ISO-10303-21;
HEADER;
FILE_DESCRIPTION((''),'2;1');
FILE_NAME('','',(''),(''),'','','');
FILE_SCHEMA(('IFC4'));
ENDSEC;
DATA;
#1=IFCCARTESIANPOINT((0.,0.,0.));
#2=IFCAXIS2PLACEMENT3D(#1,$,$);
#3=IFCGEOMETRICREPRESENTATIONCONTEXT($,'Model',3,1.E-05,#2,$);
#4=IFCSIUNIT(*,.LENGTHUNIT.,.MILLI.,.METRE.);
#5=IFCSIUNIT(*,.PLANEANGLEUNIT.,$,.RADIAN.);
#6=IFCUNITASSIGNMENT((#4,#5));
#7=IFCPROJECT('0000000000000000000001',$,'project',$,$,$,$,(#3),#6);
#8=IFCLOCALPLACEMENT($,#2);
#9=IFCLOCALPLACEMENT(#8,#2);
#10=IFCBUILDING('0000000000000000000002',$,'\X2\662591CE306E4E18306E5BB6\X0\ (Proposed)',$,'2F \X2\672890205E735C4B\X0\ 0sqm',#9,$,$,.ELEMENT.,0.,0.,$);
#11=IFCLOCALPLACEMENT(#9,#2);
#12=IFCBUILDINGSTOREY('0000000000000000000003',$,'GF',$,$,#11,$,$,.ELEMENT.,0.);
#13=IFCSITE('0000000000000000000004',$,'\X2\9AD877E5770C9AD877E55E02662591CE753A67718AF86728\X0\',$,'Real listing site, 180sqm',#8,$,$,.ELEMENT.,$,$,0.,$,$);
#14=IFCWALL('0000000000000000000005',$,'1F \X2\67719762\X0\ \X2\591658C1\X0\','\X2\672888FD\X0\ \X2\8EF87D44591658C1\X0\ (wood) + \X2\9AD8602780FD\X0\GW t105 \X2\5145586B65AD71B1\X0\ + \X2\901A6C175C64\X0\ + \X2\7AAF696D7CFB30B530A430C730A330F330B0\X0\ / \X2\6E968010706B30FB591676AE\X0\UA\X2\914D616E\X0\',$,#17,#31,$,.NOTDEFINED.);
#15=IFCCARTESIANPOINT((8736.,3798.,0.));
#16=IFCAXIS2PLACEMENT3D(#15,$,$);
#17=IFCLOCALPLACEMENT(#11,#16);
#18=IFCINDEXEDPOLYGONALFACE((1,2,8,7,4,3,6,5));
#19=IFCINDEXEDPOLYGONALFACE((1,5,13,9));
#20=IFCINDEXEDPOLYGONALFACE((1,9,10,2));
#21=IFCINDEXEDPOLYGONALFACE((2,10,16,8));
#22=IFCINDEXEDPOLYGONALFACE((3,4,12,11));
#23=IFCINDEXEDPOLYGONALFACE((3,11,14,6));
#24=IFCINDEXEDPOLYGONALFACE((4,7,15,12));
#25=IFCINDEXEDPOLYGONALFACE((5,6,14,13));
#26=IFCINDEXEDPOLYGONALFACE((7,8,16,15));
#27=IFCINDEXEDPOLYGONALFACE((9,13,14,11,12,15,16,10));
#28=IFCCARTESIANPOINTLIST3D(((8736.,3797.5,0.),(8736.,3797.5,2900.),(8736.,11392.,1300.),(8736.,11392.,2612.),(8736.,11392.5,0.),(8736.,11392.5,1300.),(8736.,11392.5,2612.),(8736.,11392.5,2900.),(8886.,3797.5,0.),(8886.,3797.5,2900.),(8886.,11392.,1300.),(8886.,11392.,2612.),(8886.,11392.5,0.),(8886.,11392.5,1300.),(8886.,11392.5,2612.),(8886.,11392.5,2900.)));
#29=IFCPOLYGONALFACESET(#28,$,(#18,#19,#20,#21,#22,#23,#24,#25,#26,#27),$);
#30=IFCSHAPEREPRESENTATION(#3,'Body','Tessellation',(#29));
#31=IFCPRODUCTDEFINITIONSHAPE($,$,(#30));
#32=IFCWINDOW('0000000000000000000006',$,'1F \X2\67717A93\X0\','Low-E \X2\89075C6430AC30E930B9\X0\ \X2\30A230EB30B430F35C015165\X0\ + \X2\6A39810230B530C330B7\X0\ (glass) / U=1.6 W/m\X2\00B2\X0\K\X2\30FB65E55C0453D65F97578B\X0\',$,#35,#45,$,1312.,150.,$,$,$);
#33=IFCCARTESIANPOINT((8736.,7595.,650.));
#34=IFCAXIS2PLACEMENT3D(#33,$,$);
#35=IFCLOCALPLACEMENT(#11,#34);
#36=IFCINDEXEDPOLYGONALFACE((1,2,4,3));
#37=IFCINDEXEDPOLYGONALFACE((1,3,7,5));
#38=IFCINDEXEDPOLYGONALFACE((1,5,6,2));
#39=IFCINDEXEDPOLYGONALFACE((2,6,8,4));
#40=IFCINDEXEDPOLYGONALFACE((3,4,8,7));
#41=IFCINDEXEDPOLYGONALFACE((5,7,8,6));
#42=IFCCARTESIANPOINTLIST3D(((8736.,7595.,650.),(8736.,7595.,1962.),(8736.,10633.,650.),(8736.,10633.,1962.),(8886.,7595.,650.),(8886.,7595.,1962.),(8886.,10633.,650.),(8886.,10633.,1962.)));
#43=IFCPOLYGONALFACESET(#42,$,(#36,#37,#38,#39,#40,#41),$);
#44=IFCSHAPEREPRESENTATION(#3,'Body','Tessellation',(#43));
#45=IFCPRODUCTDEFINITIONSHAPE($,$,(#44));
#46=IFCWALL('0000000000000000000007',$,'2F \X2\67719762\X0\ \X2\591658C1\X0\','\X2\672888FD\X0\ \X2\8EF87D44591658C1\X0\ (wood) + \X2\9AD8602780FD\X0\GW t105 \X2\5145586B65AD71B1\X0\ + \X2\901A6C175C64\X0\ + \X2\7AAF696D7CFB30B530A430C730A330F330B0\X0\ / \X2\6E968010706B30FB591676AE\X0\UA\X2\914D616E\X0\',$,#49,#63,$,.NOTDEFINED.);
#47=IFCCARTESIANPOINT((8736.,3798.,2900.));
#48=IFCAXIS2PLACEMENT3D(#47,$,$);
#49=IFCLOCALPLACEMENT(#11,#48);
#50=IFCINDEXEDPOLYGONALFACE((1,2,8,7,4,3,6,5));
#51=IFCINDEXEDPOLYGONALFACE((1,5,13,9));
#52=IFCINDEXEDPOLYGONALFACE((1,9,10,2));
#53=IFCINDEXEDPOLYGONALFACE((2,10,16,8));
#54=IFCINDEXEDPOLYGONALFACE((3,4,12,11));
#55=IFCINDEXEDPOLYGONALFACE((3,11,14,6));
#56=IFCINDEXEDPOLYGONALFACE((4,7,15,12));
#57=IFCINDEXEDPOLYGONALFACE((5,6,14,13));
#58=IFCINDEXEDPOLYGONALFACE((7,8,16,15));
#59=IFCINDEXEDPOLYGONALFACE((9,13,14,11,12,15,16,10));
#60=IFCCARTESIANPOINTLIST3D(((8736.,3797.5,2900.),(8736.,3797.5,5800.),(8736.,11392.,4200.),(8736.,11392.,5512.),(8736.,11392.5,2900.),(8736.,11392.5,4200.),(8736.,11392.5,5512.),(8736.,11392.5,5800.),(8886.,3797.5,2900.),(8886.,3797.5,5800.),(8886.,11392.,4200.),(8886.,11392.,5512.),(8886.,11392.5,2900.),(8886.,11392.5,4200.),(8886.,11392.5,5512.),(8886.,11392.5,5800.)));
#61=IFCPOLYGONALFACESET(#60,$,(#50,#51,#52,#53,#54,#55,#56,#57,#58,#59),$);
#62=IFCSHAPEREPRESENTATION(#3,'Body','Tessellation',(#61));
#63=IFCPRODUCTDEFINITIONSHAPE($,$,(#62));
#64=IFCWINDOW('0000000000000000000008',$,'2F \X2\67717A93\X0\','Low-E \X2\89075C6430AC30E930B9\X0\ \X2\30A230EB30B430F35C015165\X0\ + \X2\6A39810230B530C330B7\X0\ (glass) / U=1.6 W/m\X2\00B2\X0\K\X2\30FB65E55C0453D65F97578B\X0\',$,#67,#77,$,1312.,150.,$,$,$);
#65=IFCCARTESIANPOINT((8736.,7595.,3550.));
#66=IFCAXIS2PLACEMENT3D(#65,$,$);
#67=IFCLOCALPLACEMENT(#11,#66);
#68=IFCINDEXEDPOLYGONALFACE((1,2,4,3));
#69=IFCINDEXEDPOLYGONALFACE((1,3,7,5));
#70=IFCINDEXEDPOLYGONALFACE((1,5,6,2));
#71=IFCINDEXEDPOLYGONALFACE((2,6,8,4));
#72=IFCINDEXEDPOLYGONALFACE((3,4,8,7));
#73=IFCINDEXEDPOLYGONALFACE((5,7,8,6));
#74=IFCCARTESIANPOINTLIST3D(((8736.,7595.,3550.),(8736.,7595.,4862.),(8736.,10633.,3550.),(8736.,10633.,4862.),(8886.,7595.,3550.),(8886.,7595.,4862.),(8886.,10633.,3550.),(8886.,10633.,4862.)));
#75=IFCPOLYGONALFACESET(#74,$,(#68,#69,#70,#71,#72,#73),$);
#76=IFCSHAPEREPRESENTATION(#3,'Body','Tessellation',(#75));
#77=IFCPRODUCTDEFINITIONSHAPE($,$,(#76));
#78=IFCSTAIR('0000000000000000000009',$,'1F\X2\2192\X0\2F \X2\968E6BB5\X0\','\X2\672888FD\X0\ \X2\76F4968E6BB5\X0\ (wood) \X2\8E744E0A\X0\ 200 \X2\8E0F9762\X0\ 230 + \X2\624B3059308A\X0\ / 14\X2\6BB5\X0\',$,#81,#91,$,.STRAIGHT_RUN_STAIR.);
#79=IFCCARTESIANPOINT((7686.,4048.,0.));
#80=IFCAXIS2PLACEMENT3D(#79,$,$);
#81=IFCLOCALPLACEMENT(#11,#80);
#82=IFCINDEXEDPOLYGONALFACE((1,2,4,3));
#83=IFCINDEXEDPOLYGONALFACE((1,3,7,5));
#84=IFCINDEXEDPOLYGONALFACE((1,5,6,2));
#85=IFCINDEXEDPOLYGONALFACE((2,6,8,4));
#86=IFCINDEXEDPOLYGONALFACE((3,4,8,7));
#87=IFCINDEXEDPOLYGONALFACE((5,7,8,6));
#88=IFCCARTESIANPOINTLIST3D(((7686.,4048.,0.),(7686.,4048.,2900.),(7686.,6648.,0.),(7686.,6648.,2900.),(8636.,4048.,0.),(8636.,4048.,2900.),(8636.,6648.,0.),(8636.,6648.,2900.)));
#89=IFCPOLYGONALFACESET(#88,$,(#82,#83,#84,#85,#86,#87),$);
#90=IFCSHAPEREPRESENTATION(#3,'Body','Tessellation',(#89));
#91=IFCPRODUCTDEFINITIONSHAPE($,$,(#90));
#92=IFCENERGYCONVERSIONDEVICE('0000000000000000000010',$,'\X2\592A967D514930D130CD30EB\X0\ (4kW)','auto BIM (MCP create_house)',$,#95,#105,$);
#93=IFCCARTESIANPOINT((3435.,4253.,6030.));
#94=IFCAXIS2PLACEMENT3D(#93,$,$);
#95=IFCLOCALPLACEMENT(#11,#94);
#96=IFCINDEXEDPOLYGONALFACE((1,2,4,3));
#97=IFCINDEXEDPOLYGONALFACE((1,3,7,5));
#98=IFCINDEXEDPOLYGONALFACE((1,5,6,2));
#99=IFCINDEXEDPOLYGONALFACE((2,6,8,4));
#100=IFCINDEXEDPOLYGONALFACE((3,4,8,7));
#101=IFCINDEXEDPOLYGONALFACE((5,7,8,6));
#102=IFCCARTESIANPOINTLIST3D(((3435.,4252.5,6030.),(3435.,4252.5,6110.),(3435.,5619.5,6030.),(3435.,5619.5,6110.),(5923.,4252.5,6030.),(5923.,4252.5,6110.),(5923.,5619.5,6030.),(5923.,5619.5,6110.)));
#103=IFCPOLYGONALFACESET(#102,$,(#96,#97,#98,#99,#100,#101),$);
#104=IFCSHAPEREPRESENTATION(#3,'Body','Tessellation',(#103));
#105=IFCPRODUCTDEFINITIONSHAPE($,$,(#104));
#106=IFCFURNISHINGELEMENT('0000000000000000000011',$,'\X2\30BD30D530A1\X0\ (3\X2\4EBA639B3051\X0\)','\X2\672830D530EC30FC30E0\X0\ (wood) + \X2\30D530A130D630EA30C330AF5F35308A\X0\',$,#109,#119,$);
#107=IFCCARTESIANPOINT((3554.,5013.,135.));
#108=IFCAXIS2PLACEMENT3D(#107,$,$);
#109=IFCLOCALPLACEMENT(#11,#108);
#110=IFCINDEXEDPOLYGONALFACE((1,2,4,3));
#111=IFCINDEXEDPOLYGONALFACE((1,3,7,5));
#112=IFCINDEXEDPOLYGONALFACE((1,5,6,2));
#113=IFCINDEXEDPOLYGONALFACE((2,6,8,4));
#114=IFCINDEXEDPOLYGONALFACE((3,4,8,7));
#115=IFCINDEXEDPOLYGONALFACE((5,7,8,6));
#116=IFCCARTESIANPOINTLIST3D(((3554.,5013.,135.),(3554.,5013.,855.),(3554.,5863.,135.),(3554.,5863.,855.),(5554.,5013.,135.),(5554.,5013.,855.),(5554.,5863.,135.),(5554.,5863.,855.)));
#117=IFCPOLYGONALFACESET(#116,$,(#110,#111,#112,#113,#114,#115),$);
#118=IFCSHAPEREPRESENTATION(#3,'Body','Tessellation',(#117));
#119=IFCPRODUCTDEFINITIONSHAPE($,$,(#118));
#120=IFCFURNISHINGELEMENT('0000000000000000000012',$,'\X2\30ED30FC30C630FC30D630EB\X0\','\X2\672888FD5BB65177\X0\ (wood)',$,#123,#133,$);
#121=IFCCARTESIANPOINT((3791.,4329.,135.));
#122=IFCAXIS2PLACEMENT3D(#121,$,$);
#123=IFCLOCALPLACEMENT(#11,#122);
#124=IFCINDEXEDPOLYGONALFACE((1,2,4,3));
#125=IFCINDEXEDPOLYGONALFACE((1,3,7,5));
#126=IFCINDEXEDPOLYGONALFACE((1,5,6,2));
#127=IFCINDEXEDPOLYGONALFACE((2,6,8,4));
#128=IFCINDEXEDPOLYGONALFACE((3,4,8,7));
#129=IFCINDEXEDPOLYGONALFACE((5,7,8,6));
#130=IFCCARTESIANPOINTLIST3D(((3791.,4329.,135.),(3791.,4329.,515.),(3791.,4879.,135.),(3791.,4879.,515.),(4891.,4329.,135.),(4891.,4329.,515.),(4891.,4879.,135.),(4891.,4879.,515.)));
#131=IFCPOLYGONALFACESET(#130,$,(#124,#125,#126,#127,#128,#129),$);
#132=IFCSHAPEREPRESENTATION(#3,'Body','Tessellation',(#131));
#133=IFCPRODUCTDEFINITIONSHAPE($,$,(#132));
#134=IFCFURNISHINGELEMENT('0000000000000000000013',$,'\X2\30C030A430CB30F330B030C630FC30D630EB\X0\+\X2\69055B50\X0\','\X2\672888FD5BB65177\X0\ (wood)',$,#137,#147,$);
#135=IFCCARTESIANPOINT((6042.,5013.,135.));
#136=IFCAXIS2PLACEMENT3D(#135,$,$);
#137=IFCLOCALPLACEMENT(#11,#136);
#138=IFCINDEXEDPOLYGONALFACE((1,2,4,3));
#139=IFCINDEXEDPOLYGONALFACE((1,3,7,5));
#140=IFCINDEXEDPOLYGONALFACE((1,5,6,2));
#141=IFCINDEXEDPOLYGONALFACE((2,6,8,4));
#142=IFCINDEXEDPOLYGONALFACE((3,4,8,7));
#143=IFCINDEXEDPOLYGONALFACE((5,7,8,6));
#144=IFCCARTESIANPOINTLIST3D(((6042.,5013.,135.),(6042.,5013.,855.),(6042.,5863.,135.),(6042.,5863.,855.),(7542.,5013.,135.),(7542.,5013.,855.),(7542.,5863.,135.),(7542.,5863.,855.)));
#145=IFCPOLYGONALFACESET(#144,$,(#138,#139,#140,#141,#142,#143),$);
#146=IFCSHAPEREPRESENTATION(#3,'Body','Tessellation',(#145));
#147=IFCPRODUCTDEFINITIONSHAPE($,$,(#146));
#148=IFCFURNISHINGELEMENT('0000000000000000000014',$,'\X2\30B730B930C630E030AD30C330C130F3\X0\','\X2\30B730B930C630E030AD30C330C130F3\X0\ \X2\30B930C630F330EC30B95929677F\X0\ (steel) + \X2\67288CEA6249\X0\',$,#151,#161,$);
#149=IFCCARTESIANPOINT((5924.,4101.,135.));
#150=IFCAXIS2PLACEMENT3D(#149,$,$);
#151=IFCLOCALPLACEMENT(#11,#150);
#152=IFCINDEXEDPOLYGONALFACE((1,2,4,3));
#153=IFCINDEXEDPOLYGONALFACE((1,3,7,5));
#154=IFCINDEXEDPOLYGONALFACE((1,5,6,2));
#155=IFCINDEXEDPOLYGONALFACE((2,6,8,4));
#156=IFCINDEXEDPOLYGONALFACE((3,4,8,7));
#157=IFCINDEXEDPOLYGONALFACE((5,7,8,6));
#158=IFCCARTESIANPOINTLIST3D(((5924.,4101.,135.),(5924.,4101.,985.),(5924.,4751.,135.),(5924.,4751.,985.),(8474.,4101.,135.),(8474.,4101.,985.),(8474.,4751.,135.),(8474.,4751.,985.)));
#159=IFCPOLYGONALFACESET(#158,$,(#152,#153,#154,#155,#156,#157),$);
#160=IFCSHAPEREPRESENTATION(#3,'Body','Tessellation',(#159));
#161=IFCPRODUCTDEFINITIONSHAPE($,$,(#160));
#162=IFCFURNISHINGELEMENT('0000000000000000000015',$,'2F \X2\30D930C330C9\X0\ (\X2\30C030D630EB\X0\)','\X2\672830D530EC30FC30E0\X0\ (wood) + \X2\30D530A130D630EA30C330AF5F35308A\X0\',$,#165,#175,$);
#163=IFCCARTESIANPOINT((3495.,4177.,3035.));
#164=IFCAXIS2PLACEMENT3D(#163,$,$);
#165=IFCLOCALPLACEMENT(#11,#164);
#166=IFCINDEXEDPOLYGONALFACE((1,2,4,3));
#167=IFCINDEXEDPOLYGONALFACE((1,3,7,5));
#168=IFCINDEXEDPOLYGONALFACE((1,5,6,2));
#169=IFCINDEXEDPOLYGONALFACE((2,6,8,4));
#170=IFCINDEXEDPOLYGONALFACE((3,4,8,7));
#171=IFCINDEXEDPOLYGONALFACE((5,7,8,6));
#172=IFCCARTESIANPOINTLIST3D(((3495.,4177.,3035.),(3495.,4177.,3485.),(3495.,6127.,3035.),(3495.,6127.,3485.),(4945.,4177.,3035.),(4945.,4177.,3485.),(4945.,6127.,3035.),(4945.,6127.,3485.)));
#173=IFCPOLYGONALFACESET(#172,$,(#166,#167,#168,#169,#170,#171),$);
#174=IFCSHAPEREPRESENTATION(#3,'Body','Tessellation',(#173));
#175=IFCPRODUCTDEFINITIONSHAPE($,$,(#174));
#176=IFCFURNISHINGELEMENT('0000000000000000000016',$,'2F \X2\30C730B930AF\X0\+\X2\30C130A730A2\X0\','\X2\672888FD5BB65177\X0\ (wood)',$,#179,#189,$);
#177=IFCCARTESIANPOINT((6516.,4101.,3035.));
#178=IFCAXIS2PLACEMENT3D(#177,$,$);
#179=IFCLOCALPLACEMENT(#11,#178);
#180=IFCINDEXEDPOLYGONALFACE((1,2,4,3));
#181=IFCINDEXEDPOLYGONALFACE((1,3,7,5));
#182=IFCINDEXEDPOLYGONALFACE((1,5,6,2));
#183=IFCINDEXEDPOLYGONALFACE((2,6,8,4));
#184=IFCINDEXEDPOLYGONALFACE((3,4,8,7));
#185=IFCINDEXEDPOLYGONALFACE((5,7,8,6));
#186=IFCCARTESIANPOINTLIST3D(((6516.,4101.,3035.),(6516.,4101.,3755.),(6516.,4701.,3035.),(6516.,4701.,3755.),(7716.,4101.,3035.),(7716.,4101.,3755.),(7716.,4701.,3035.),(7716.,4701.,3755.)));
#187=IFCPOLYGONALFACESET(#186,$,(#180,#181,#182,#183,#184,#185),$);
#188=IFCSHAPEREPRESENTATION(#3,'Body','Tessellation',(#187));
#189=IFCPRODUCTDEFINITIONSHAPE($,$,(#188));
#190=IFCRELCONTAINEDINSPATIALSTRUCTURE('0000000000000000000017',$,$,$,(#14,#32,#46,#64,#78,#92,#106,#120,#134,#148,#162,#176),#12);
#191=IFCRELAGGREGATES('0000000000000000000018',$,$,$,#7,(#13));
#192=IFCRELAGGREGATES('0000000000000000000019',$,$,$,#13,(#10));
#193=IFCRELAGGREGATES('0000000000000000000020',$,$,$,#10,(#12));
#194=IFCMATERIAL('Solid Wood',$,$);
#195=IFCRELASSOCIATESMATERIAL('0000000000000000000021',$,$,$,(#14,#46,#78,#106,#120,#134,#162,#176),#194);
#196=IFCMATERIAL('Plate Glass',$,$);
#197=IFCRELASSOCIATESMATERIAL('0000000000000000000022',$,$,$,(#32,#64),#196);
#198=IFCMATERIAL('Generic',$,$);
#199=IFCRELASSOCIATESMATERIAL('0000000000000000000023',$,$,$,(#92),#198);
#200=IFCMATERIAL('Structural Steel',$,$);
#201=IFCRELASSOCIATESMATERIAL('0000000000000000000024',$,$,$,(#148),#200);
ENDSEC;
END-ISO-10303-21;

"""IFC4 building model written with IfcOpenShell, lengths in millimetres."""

from ifc_helpers import new_model, si_unit, frame, frame_2d, origin, place, context, project, spatial, rectangle, extrude, material, element, fill, save


model = new_model("IFC4")

# Units and contexts
model_context = context("Model", 3, precision=1e-05, world=origin())
ifc_project = project(units=[si_unit("LENGTHUNIT", "METRE", prefix="MILLI"), si_unit("PLANEANGLEUNIT", "RADIAN")], contexts=[model_context])

# Site, building, storey
site_placement = place(None, origin())
site = spatial("IfcSite", under=ifc_project, at=site_placement, Name="高知県高知市春野町東諸木", ObjectType="Real listing site, 180sqm", CompositionType="ELEMENT", RefElevation=0.0)
building_placement = place(site_placement, origin())
building = spatial("IfcBuilding", under=site, at=building_placement, Name="春野の丘の家 (Proposed)", ObjectType="2F 木造平屋 0sqm", CompositionType="ELEMENT", ElevationOfRefHeight=0.0, ElevationOfTerrain=0.0)
storey_placement = place(building_placement, origin())
storey = spatial("IfcBuildingStorey", under=building, at=storey_placement, Name="GF", CompositionType="ELEMENT", Elevation=0.0)

# Wall, opening, window
ifc_material_1 = material(Name="Solid Wood")
wall_1_placement = place(storey_placement, frame((8736.0, 3798.0, 0.0)))
wall_1 = element("IfcWall", 1, at=wall_1_placement, inside=storey, material=ifc_material_1, Name="1F 東面 外壁", Description="木製 軸組外壁 (wood) + 高性能GW t105 充填断熱 + 通気層 + 窯業系サイディング / 準耐火・外皮UA配慮", PredefinedType="NOTDEFINED", context=model_context, shape_type="SweptSolid", body=[
    extrude(rectangle(XDim=150.0, YDim=7595.0, at=frame_2d((75.0, 3797.0))), frame((8736.0, 3798.0, 0.0)), (0.0, 0.0, 1.0), 2900.0),
])
opening_1_placement = place(storey_placement, frame((8736.0, 7595.0, 650.0)))
opening_1 = element("IfcOpeningElement", 2, at=opening_1_placement, cuts=wall_1, PredefinedType="NOTDEFINED", context=model_context, shape_type="SweptSolid", body=[
    extrude(rectangle(XDim=150.0, YDim=3038.0, at=frame_2d((75.0, 1519.0))), frame((8736.0, 7595.0, 650.0)), (0.0, 0.0, 1.0), 1312.0),
])
ifc_material_2 = material(Name="Plate Glass")
window_1_placement = place(storey_placement, frame((8736.0, 7595.0, 650.0)))
window_1 = element("IfcWindow", 3, at=window_1_placement, inside=storey, material=ifc_material_2, Name="1F 東窓", Description="Low-E 複層ガラス アルゴン封入 + 樹脂サッシ (glass) / U=1.6 W/m²K・日射取得型", OverallHeight=1312.0, OverallWidth=150.0, context=model_context, shape_type="SweptSolid", body=[
    extrude(rectangle(XDim=150.0, YDim=3038.0, at=frame_2d((75.0, 1519.0))), frame((8736.0, 7595.0, 650.0)), (0.0, 0.0, 1.0), 1312.0),
])
fill(opening_1, window_1)

# Wall, opening, window
wall_2_placement = place(storey_placement, frame((8736.0, 3798.0, 2900.0)))
wall_2 = element("IfcWall", 4, at=wall_2_placement, inside=storey, material=ifc_material_1, Name="2F 東面 外壁", Description="木製 軸組外壁 (wood) + 高性能GW t105 充填断熱 + 通気層 + 窯業系サイディング / 準耐火・外皮UA配慮", PredefinedType="NOTDEFINED", context=model_context, shape_type="SweptSolid", body=[
    extrude(rectangle(XDim=150.0, YDim=7595.0, at=frame_2d((75.0, 3797.0))), frame((8736.0, 3798.0, 2900.0)), (0.0, 0.0, 1.0), 2900.0),
])
opening_2_placement = place(storey_placement, frame((8736.0, 7595.0, 3550.0)))
opening_2 = element("IfcOpeningElement", 5, at=opening_2_placement, cuts=wall_2, PredefinedType="NOTDEFINED", context=model_context, shape_type="SweptSolid", body=[
    extrude(rectangle(XDim=150.0, YDim=3038.0, at=frame_2d((75.0, 1519.0))), frame((8736.0, 7595.0, 3550.0)), (0.0, 0.0, 1.0), 1312.0),
])
window_2_placement = place(storey_placement, frame((8736.0, 7595.0, 3550.0)))
window_2 = element("IfcWindow", 6, at=window_2_placement, inside=storey, material=ifc_material_2, Name="2F 東窓", Description="Low-E 複層ガラス アルゴン封入 + 樹脂サッシ (glass) / U=1.6 W/m²K・日射取得型", OverallHeight=1312.0, OverallWidth=150.0, context=model_context, shape_type="SweptSolid", body=[
    extrude(rectangle(XDim=150.0, YDim=3038.0, at=frame_2d((75.0, 1519.0))), frame((8736.0, 7595.0, 3550.0)), (0.0, 0.0, 1.0), 1312.0),
])
fill(opening_2, window_2)

# Stair
stair_placement = place(storey_placement, frame((7686.0, 4048.0, 0.0)))
element("IfcStair", 7, at=stair_placement, inside=storey, material=ifc_material_1, Name="1F→2F 階段", Description="木製 直階段 (wood) 蹴上 200 踏面 230 + 手すり / 14段", PredefinedType="STRAIGHT_RUN_STAIR", context=model_context, shape_type="SweptSolid", body=[
    extrude(rectangle(XDim=950.0, YDim=2600.0, at=frame_2d((475.0, 1300.0))), frame((7686.0, 4048.0, 0.0)), (0.0, 0.0, 1.0), 2900.0),
])

# Energy conversion device
ifc_material_3 = material(Name="Generic")
energy_conversion_device_placement = place(storey_placement, frame((3435.0, 4253.0, 6030.0)))
element("IfcEnergyConversionDevice", 8, at=energy_conversion_device_placement, inside=storey, material=ifc_material_3, Name="太陽光パネル (4kW)", Description="auto BIM (MCP create_house)", context=model_context, shape_type="SweptSolid", body=[
    extrude(rectangle(XDim=2488.0, YDim=1367.0, at=frame_2d((1244.0, 683.0))), frame((3435.0, 4253.0, 6030.0)), (0.0, 0.0, 1.0), 80.0),
])

# Furnishing elements
furnishing_1_placement = place(storey_placement, frame((3554.0, 5013.0, 135.0)))
element("IfcFurnishingElement", 9, at=furnishing_1_placement, inside=storey, material=ifc_material_1, Name="ソファ (3人掛け)", Description="木フレーム (wood) + ファブリック張り", context=model_context, shape_type="SweptSolid", body=[
    extrude(rectangle(XDim=2000.0, YDim=850.0, at=frame_2d((1000.0, 425.0))), frame((3554.0, 5013.0, 135.0)), (0.0, 0.0, 1.0), 720.0),
])
furnishing_2_placement = place(storey_placement, frame((3791.0, 4329.0, 135.0)))
element("IfcFurnishingElement", 10, at=furnishing_2_placement, inside=storey, material=ifc_material_1, Name="ローテーブル", Description="木製家具 (wood)", context=model_context, shape_type="SweptSolid", body=[
    extrude(rectangle(XDim=1100.0, YDim=550.0, at=frame_2d((550.0, 275.0))), frame((3791.0, 4329.0, 135.0)), (0.0, 0.0, 1.0), 380.0),
])
furnishing_3_placement = place(storey_placement, frame((6042.0, 5013.0, 135.0)))
element("IfcFurnishingElement", 11, at=furnishing_3_placement, inside=storey, material=ifc_material_1, Name="ダイニングテーブル+椅子", Description="木製家具 (wood)", context=model_context, shape_type="SweptSolid", body=[
    extrude(rectangle(XDim=1500.0, YDim=850.0, at=frame_2d((750.0, 425.0))), frame((6042.0, 5013.0, 135.0)), (0.0, 0.0, 1.0), 720.0),
])
ifc_material_4 = material(Name="Structural Steel")
furnishing_4_placement = place(storey_placement, frame((5924.0, 4101.0, 135.0)))
element("IfcFurnishingElement", 12, at=furnishing_4_placement, inside=storey, material=ifc_material_4, Name="システムキッチン", Description="システムキッチン ステンレス天板 (steel) + 木質扉", context=model_context, shape_type="SweptSolid", body=[
    extrude(rectangle(XDim=2550.0, YDim=650.0, at=frame_2d((1275.0, 325.0))), frame((5924.0, 4101.0, 135.0)), (0.0, 0.0, 1.0), 850.0),
])
furnishing_5_placement = place(storey_placement, frame((3495.0, 4177.0, 3035.0)))
element("IfcFurnishingElement", 13, at=furnishing_5_placement, inside=storey, material=ifc_material_1, Name="2F ベッド (ダブル)", Description="木フレーム (wood) + ファブリック張り", context=model_context, shape_type="SweptSolid", body=[
    extrude(rectangle(XDim=1450.0, YDim=1950.0, at=frame_2d((725.0, 975.0))), frame((3495.0, 4177.0, 3035.0)), (0.0, 0.0, 1.0), 450.0),
])
furnishing_6_placement = place(storey_placement, frame((6516.0, 4101.0, 3035.0)))
element("IfcFurnishingElement", 14, at=furnishing_6_placement, inside=storey, material=ifc_material_1, Name="2F デスク+チェア", Description="木製家具 (wood)", context=model_context, shape_type="SweptSolid", body=[
    extrude(rectangle(XDim=1200.0, YDim=600.0, at=frame_2d((600.0, 300.0))), frame((6516.0, 4101.0, 3035.0)), (0.0, 0.0, 1.0), 720.0),
])

save(model, "model.ifc")
